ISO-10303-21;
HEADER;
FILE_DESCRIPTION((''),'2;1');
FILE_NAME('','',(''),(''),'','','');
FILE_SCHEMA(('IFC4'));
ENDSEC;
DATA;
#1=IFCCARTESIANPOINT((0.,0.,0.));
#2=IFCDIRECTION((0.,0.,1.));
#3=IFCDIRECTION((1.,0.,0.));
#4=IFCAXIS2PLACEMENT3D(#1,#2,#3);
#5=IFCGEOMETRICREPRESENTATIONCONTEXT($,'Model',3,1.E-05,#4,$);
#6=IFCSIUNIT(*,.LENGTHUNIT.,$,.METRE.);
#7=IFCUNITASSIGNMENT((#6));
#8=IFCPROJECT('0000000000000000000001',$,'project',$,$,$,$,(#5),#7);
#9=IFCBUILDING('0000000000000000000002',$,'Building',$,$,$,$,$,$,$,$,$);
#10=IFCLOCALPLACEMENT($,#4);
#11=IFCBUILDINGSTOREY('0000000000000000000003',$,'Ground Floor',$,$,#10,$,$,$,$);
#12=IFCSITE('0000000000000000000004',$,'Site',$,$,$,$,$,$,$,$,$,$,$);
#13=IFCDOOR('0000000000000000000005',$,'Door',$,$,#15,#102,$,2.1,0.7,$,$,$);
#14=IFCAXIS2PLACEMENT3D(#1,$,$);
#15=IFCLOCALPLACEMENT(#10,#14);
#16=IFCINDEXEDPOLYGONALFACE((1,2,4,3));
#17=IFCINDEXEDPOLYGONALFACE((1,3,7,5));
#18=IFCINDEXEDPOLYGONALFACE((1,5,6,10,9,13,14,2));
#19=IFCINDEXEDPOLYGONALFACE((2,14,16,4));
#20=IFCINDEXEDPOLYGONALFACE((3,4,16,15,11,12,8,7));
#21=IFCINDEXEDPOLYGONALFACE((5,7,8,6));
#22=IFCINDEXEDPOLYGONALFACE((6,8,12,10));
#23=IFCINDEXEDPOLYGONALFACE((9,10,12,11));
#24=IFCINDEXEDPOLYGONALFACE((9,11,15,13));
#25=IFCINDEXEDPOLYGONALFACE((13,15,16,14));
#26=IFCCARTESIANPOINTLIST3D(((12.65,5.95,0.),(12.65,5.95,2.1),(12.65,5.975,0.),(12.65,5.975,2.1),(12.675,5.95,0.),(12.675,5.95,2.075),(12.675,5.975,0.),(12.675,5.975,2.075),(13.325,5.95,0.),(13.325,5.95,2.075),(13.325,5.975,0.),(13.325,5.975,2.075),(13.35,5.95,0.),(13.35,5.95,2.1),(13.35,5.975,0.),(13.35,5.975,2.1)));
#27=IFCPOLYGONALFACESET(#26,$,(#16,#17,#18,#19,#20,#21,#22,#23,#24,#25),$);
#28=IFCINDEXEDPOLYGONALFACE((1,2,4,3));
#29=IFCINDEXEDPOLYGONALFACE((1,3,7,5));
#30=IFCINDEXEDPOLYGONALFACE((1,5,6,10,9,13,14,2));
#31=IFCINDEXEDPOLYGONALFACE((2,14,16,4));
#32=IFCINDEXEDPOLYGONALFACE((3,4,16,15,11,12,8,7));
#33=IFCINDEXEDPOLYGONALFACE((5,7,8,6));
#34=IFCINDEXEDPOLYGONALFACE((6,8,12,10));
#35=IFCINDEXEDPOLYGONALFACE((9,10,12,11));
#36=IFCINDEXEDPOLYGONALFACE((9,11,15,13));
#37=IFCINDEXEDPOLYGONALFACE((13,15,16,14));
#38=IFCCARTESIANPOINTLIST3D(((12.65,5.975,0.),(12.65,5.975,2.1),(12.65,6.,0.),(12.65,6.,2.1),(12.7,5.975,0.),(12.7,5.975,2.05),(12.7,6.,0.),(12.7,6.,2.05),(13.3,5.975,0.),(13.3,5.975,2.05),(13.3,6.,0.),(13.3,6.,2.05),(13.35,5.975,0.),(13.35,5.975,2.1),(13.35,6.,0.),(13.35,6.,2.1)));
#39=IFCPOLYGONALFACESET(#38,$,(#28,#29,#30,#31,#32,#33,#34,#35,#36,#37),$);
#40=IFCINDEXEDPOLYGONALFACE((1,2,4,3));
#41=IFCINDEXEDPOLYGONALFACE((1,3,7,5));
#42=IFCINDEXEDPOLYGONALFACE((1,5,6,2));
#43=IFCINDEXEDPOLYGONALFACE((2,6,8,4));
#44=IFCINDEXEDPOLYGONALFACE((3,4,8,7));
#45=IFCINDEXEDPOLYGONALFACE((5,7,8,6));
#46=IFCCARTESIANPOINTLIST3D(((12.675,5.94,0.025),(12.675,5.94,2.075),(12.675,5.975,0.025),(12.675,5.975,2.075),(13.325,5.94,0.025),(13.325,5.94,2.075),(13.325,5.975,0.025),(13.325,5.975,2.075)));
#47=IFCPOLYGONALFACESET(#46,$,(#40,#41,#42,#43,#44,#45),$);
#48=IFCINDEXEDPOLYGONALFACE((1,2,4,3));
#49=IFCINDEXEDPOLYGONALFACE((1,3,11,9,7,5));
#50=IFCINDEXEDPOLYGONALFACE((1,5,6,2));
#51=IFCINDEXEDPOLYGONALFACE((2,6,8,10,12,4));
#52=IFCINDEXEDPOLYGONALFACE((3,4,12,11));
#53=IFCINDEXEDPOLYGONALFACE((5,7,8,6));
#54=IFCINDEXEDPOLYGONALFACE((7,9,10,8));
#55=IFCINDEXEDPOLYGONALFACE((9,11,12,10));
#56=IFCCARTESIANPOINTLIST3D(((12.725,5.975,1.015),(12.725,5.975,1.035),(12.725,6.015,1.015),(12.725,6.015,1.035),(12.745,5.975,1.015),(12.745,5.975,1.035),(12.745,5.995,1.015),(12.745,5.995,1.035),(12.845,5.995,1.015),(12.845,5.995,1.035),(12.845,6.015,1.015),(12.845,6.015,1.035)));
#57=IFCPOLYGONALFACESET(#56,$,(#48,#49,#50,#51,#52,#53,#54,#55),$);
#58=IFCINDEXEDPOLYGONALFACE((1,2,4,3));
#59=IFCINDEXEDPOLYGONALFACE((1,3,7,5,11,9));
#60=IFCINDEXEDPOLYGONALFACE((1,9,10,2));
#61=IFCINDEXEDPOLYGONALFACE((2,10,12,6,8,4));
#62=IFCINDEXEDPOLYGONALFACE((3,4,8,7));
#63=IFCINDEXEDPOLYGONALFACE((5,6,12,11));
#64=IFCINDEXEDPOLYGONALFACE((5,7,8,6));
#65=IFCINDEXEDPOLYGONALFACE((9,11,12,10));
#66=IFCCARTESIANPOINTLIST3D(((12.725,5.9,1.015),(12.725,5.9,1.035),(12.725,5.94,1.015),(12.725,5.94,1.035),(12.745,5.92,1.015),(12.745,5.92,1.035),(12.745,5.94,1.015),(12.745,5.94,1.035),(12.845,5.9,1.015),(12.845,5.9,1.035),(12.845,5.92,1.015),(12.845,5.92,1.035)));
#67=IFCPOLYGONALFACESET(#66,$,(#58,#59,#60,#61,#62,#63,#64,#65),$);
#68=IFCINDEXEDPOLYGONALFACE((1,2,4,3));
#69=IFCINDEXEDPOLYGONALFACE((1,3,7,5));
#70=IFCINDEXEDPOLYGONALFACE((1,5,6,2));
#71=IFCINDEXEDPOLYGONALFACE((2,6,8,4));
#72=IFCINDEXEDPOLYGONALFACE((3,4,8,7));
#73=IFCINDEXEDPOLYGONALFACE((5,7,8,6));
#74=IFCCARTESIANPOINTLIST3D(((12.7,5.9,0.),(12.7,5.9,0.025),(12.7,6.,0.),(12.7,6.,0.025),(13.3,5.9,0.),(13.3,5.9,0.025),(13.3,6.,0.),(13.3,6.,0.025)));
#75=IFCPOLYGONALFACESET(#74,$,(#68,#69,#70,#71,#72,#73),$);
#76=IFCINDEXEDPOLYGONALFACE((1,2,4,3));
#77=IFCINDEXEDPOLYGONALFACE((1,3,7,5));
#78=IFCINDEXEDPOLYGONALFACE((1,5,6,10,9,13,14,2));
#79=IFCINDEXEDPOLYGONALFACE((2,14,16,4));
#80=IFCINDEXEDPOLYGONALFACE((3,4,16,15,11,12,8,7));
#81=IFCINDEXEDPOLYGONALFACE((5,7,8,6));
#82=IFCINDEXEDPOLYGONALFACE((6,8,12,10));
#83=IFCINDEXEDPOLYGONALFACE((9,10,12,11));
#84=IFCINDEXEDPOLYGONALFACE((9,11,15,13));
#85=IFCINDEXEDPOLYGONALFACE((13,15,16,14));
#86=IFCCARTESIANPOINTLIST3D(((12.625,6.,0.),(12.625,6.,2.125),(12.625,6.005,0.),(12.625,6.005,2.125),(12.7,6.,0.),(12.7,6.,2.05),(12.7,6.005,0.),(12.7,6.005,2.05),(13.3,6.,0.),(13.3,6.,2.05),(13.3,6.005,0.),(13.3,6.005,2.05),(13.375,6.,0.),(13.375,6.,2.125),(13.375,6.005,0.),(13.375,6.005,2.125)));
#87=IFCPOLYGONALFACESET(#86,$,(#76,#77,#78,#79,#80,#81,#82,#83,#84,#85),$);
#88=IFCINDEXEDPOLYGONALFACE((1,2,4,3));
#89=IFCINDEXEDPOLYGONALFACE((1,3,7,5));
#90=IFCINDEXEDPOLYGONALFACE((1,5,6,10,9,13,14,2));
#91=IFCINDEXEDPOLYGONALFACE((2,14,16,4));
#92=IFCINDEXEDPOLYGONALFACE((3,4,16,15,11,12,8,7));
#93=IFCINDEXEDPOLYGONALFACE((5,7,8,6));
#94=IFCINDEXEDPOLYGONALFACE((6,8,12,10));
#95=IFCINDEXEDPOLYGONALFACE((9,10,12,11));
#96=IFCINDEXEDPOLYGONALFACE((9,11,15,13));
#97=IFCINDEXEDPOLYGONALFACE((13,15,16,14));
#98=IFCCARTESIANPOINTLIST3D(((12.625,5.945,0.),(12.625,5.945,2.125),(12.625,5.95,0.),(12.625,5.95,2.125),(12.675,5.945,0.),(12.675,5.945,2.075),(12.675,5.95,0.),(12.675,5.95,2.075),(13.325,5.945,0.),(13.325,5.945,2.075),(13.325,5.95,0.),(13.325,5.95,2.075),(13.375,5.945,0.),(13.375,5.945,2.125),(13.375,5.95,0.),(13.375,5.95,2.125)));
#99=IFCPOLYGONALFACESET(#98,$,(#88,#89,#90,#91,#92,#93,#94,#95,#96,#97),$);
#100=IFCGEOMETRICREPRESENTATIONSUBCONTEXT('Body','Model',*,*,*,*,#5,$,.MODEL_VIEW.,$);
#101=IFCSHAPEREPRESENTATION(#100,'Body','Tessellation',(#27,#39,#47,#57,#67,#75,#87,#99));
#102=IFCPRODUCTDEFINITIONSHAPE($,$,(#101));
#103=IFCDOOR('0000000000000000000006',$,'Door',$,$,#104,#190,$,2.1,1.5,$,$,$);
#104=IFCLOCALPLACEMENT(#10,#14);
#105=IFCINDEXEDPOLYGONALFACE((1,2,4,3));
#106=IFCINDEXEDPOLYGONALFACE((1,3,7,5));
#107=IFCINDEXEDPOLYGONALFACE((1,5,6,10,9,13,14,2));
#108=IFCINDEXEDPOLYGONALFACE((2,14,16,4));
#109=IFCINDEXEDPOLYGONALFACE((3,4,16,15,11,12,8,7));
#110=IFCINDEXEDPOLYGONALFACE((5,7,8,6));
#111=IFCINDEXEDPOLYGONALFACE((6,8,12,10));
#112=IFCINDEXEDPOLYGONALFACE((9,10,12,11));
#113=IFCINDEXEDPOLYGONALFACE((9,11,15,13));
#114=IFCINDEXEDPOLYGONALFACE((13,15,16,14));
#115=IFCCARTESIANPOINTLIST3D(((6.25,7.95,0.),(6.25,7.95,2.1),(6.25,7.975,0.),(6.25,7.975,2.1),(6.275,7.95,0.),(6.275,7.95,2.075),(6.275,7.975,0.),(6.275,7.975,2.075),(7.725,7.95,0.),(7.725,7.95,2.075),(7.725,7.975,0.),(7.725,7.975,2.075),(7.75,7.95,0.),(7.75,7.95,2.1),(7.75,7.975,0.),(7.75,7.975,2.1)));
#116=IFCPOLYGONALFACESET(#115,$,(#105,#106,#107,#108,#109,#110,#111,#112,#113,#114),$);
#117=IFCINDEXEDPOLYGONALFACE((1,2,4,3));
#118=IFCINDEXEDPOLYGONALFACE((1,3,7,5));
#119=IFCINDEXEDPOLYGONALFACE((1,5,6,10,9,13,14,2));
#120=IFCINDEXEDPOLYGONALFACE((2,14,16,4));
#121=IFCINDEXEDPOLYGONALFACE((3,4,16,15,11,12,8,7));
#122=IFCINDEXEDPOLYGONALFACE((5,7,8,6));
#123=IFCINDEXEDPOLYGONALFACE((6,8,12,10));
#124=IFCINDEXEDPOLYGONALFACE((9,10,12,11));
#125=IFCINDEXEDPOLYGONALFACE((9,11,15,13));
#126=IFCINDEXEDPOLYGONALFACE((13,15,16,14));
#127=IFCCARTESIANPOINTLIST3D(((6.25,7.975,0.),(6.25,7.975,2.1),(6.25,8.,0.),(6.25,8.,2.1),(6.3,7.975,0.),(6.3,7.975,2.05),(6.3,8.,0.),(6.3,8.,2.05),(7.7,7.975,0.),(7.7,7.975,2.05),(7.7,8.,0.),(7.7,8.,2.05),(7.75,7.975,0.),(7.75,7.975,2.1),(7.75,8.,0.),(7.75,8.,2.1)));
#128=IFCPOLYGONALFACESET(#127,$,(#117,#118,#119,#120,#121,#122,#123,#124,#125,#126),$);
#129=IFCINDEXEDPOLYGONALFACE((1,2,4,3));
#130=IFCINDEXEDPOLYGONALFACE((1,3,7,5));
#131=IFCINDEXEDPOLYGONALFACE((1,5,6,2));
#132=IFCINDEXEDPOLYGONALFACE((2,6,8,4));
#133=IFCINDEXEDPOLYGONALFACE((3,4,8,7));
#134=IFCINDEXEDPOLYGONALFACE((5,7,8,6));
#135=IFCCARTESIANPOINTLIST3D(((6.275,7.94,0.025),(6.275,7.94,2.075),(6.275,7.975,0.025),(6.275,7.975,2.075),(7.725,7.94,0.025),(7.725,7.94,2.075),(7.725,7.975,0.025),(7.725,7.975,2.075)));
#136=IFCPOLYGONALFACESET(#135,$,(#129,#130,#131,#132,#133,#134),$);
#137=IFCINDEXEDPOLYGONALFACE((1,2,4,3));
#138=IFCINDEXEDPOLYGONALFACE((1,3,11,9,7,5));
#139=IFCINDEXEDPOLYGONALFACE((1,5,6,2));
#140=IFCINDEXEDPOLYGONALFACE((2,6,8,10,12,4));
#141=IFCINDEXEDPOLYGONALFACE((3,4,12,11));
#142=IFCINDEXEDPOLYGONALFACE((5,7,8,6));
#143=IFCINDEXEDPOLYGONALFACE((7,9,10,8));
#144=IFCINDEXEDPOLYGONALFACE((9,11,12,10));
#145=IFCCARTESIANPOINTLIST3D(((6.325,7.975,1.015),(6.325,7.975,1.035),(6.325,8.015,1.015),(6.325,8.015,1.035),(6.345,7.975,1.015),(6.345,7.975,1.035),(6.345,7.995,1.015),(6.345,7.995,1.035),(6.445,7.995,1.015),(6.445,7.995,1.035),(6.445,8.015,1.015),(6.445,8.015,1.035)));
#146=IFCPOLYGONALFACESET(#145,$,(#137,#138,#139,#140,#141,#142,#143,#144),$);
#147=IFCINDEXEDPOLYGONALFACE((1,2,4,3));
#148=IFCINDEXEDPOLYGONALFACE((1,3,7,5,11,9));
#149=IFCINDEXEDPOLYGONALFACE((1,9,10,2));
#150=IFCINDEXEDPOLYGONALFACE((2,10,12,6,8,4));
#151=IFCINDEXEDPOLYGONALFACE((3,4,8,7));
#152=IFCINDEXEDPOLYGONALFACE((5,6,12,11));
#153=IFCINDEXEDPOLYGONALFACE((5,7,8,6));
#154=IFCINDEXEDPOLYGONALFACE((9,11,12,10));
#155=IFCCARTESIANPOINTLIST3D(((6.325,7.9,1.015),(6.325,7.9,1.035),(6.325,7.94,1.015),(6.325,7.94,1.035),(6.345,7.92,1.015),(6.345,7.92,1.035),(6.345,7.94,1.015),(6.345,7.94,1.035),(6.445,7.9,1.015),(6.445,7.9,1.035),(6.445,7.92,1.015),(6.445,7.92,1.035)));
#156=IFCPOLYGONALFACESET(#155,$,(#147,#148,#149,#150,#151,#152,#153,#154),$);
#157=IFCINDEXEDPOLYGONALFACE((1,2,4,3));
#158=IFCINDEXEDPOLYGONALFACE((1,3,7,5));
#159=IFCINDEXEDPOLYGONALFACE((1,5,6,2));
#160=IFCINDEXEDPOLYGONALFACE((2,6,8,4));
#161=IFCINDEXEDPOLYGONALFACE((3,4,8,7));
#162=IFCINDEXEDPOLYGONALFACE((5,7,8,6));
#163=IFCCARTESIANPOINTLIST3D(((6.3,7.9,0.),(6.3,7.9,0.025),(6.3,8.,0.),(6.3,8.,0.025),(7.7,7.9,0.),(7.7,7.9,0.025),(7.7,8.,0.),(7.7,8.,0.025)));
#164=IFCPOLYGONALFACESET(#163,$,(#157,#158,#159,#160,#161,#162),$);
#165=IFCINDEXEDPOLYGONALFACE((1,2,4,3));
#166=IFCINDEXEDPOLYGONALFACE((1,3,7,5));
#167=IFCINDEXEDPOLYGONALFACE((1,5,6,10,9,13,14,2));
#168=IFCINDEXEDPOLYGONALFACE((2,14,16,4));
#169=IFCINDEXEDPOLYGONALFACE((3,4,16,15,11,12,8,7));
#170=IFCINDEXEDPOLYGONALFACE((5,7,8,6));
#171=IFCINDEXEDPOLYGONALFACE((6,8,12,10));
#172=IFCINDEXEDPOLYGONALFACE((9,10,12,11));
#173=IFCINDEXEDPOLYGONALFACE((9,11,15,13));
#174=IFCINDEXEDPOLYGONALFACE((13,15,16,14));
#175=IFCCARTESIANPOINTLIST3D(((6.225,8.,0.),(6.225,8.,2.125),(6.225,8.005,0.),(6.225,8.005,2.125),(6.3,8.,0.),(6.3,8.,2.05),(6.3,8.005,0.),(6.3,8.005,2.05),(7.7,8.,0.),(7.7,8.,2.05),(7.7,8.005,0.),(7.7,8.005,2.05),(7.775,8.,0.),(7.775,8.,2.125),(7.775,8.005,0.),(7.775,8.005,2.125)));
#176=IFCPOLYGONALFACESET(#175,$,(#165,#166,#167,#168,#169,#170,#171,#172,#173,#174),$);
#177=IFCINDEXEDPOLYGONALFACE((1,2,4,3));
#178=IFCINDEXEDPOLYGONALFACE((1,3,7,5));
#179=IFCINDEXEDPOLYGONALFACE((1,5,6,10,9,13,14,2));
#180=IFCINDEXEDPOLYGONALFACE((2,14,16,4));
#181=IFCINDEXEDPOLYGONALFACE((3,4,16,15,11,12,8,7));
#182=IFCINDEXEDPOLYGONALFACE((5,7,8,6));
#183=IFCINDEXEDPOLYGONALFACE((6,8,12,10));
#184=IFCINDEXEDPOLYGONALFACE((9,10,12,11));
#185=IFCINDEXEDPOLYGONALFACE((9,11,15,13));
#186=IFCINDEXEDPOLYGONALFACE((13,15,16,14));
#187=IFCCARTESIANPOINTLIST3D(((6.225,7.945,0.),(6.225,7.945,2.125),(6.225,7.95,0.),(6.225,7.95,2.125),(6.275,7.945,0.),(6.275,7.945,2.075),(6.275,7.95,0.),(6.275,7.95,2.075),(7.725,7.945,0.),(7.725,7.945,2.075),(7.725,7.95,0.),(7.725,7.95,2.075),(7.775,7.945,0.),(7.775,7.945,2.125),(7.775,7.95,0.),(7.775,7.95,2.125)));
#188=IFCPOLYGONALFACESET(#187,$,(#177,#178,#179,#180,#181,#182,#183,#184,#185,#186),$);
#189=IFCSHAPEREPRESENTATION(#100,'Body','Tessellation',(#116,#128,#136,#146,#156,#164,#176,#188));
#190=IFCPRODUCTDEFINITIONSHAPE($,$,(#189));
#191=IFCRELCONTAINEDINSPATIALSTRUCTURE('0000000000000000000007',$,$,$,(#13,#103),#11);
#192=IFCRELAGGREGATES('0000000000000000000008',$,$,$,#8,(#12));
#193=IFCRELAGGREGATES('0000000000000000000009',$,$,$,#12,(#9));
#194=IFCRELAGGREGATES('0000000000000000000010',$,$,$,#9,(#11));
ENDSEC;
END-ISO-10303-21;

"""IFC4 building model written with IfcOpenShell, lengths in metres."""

from ifc_helpers import new_model, si_unit, frame, origin_with_axes, place, context, subcontext, project, spatial, line, indexed_curve, outline, extrude, element, save


model = new_model("IFC4")

# Units and contexts
model_context = context("Model", 3, precision=1e-05, world=origin_with_axes())
body_context = subcontext(model_context, "Body", "Model", "MODEL_VIEW")
ifc_project = project(units=[si_unit("LENGTHUNIT", "METRE")], contexts=[model_context])

# Site, building, storey
site = spatial("IfcSite", under=ifc_project, Name="Site")
building = spatial("IfcBuilding", under=site, Name="Building")
storey_placement = place(None, origin_with_axes())
storey = spatial("IfcBuildingStorey", under=building, at=storey_placement, Name="Ground Floor")

# Doors
door_1_placement = place(storey_placement, frame((13.35, 6.0, 0.0), z_axis=(0.0, 0.0, 1.0), x_axis=(-1.0, 0.0, 0.0)))
element("IfcDoor", 1, at=door_1_placement, inside=storey, Name="Door", OverallHeight=2.1, OverallWidth=0.7, context=body_context, shape_type="SweptSolid", body=[
    extrude(outline(indexed_curve([(0.0, 0.0), (0.0, 2.1), (0.7, 2.1), (0.7, 0.0), (0.675, 0.0), (0.675, 2.075), (0.025, 2.075), (0.025, 0.0)], segments=[line(1, 2, 3, 4, 5, 6, 7, 8, 1)])), frame((0.0, 0.025, 0.0), z_axis=(0.0, -1.0, 0.0), x_axis=(1.0, 0.0, 0.0)), (0.0, 0.0, -1.0), 0.025),
    extrude(outline(indexed_curve([(0.0, 0.0), (0.0, 2.1), (0.7, 2.1), (0.7, 0.0), (0.65, 0.0), (0.65, 2.05), (0.05, 2.05), (0.05, 0.0)], segments=[line(1, 2, 3, 4, 5, 6, 7, 8, 1)])), frame((0.0, 0.0, 0.0), z_axis=(0.0, -1.0, 0.0), x_axis=(1.0, 0.0, 0.0)), (0.0, 0.0, -1.0), 0.025),
    extrude(outline(indexed_curve([(0.0, 0.0), (0.65, 0.0), (0.65, 0.035), (0.0, 0.035)], segments=[line(1, 2, 3, 4, 1)])), frame((0.025, 0.025, 0.025), z_axis=(0.0, 0.0, 1.0), x_axis=(1.0, 0.0, 0.0)), (0.0, 0.0, 1.0), 2.05),
    extrude(outline(indexed_curve([(0.0, 0.0), (0.0, -0.04), (-0.12, -0.04), (-0.12, -0.02), (-0.02, -0.02), (-0.02, 0.0)], segments=[line(1, 2, 3, 4, 5, 6, 1)])), frame((0.625, 0.025, 1.015), z_axis=(0.0, 0.0, 1.0), x_axis=(1.0, 0.0, 0.0)), (0.0, 0.0, 1.0), 0.02),
    extrude(outline(indexed_curve([(0.0, 0.0), (0.0, 0.04), (-0.12, 0.04), (-0.12, 0.02), (-0.02, 0.02), (-0.02, 0.0)], segments=[line(1, 2, 3, 4, 5, 6, 1)])), frame((0.625, 0.06, 1.015), z_axis=(0.0, 0.0, 1.0), x_axis=(1.0, 0.0, 0.0)), (0.0, 0.0, 1.0), 0.02),
    extrude(outline(indexed_curve([(0.0, 0.0), (0.6, 0.0), (0.6, 0.1), (0.0, 0.1)], segments=[line(1, 2, 3, 4, 1)])), frame((0.05, 0.0, 0.0), z_axis=(0.0, 0.0, 1.0), x_axis=(1.0, 0.0, 0.0)), (0.0, 0.0, 1.0), 0.025),
    extrude(outline(indexed_curve([(0.0, 0.0), (0.0, 2.125), (0.75, 2.125), (0.75, 0.0), (0.675, 0.0), (0.675, 2.05), (0.075, 2.05), (0.075, 0.0)], segments=[line(1, 2, 3, 4, 5, 6, 7, 8, 1)])), frame((-0.025, -0.005, 0.0), z_axis=(0.0, -1.0, 0.0), x_axis=(1.0, 0.0, 0.0)), (0.0, 0.0, -1.0), 0.005),
    extrude(outline(indexed_curve([(0.0, 0.0), (0.0, 2.125), (0.75, 2.125), (0.75, 0.0), (0.7, 0.0), (0.7, 2.075), (0.05, 2.075), (0.05, 0.0)], segments=[line(1, 2, 3, 4, 5, 6, 7, 8, 1)])), frame((-0.025, 0.05, 0.0), z_axis=(0.0, -1.0, 0.0), x_axis=(1.0, 0.0, 0.0)), (0.0, 0.0, -1.0), 0.005),
])
door_2_placement = place(storey_placement, frame((7.75, 8.0, 0.0), z_axis=(0.0, 0.0, 1.0), x_axis=(-1.0, 0.0, 0.0)))
element("IfcDoor", 2, at=door_2_placement, inside=storey, Name="Door", OverallHeight=2.1, OverallWidth=1.5, context=body_context, shape_type="SweptSolid", body=[
    extrude(outline(indexed_curve([(0.0, 0.0), (0.0, 2.1), (1.5, 2.1), (1.5, 0.0), (1.475, 0.0), (1.475, 2.075), (0.025, 2.075), (0.025, 0.0)], segments=[line(1, 2, 3, 4, 5, 6, 7, 8, 1)])), frame((0.0, 0.025, 0.0), z_axis=(0.0, -1.0, 0.0), x_axis=(1.0, 0.0, 0.0)), (0.0, 0.0, -1.0), 0.025),
    extrude(outline(indexed_curve([(0.0, 0.0), (0.0, 2.1), (1.5, 2.1), (1.5, 0.0), (1.45, 0.0), (1.45, 2.05), (0.05, 2.05), (0.05, 0.0)], segments=[line(1, 2, 3, 4, 5, 6, 7, 8, 1)])), frame((0.0, 0.0, 0.0), z_axis=(0.0, -1.0, 0.0), x_axis=(1.0, 0.0, 0.0)), (0.0, 0.0, -1.0), 0.025),
    extrude(outline(indexed_curve([(0.0, 0.0), (1.45, 0.0), (1.45, 0.035), (0.0, 0.035)], segments=[line(1, 2, 3, 4, 1)])), frame((0.025, 0.025, 0.025), z_axis=(0.0, 0.0, 1.0), x_axis=(1.0, 0.0, 0.0)), (0.0, 0.0, 1.0), 2.05),
    extrude(outline(indexed_curve([(0.0, 0.0), (0.0, -0.04), (-0.12, -0.04), (-0.12, -0.02), (-0.02, -0.02), (-0.02, 0.0)], segments=[line(1, 2, 3, 4, 5, 6, 1)])), frame((1.425, 0.025, 1.015), z_axis=(0.0, 0.0, 1.0), x_axis=(1.0, 0.0, 0.0)), (0.0, 0.0, 1.0), 0.02),
    extrude(outline(indexed_curve([(0.0, 0.0), (0.0, 0.04), (-0.12, 0.04), (-0.12, 0.02), (-0.02, 0.02), (-0.02, 0.0)], segments=[line(1, 2, 3, 4, 5, 6, 1)])), frame((1.425, 0.06, 1.015), z_axis=(0.0, 0.0, 1.0), x_axis=(1.0, 0.0, 0.0)), (0.0, 0.0, 1.0), 0.02),
    extrude(outline(indexed_curve([(0.0, 0.0), (1.4, 0.0), (1.4, 0.1), (0.0, 0.1)], segments=[line(1, 2, 3, 4, 1)])), frame((0.05, 0.0, 0.0), z_axis=(0.0, 0.0, 1.0), x_axis=(1.0, 0.0, 0.0)), (0.0, 0.0, 1.0), 0.025),
    extrude(outline(indexed_curve([(0.0, 0.0), (0.0, 2.125), (1.55, 2.125), (1.55, 0.0), (1.475, 0.0), (1.475, 2.05), (0.075, 2.05), (0.075, 0.0)], segments=[line(1, 2, 3, 4, 5, 6, 7, 8, 1)])), frame((-0.025, -0.005, 0.0), z_axis=(0.0, -1.0, 0.0), x_axis=(1.0, 0.0, 0.0)), (0.0, 0.0, -1.0), 0.005),
    extrude(outline(indexed_curve([(0.0, 0.0), (0.0, 2.125), (1.55, 2.125), (1.55, 0.0), (1.5, 0.0), (1.5, 2.075), (0.05, 2.075), (0.05, 0.0)], segments=[line(1, 2, 3, 4, 5, 6, 7, 8, 1)])), frame((-0.025, 0.05, 0.0), z_axis=(0.0, -1.0, 0.0), x_axis=(1.0, 0.0, 0.0)), (0.0, 0.0, -1.0), 0.005),
])

save(model, "model.ifc")
